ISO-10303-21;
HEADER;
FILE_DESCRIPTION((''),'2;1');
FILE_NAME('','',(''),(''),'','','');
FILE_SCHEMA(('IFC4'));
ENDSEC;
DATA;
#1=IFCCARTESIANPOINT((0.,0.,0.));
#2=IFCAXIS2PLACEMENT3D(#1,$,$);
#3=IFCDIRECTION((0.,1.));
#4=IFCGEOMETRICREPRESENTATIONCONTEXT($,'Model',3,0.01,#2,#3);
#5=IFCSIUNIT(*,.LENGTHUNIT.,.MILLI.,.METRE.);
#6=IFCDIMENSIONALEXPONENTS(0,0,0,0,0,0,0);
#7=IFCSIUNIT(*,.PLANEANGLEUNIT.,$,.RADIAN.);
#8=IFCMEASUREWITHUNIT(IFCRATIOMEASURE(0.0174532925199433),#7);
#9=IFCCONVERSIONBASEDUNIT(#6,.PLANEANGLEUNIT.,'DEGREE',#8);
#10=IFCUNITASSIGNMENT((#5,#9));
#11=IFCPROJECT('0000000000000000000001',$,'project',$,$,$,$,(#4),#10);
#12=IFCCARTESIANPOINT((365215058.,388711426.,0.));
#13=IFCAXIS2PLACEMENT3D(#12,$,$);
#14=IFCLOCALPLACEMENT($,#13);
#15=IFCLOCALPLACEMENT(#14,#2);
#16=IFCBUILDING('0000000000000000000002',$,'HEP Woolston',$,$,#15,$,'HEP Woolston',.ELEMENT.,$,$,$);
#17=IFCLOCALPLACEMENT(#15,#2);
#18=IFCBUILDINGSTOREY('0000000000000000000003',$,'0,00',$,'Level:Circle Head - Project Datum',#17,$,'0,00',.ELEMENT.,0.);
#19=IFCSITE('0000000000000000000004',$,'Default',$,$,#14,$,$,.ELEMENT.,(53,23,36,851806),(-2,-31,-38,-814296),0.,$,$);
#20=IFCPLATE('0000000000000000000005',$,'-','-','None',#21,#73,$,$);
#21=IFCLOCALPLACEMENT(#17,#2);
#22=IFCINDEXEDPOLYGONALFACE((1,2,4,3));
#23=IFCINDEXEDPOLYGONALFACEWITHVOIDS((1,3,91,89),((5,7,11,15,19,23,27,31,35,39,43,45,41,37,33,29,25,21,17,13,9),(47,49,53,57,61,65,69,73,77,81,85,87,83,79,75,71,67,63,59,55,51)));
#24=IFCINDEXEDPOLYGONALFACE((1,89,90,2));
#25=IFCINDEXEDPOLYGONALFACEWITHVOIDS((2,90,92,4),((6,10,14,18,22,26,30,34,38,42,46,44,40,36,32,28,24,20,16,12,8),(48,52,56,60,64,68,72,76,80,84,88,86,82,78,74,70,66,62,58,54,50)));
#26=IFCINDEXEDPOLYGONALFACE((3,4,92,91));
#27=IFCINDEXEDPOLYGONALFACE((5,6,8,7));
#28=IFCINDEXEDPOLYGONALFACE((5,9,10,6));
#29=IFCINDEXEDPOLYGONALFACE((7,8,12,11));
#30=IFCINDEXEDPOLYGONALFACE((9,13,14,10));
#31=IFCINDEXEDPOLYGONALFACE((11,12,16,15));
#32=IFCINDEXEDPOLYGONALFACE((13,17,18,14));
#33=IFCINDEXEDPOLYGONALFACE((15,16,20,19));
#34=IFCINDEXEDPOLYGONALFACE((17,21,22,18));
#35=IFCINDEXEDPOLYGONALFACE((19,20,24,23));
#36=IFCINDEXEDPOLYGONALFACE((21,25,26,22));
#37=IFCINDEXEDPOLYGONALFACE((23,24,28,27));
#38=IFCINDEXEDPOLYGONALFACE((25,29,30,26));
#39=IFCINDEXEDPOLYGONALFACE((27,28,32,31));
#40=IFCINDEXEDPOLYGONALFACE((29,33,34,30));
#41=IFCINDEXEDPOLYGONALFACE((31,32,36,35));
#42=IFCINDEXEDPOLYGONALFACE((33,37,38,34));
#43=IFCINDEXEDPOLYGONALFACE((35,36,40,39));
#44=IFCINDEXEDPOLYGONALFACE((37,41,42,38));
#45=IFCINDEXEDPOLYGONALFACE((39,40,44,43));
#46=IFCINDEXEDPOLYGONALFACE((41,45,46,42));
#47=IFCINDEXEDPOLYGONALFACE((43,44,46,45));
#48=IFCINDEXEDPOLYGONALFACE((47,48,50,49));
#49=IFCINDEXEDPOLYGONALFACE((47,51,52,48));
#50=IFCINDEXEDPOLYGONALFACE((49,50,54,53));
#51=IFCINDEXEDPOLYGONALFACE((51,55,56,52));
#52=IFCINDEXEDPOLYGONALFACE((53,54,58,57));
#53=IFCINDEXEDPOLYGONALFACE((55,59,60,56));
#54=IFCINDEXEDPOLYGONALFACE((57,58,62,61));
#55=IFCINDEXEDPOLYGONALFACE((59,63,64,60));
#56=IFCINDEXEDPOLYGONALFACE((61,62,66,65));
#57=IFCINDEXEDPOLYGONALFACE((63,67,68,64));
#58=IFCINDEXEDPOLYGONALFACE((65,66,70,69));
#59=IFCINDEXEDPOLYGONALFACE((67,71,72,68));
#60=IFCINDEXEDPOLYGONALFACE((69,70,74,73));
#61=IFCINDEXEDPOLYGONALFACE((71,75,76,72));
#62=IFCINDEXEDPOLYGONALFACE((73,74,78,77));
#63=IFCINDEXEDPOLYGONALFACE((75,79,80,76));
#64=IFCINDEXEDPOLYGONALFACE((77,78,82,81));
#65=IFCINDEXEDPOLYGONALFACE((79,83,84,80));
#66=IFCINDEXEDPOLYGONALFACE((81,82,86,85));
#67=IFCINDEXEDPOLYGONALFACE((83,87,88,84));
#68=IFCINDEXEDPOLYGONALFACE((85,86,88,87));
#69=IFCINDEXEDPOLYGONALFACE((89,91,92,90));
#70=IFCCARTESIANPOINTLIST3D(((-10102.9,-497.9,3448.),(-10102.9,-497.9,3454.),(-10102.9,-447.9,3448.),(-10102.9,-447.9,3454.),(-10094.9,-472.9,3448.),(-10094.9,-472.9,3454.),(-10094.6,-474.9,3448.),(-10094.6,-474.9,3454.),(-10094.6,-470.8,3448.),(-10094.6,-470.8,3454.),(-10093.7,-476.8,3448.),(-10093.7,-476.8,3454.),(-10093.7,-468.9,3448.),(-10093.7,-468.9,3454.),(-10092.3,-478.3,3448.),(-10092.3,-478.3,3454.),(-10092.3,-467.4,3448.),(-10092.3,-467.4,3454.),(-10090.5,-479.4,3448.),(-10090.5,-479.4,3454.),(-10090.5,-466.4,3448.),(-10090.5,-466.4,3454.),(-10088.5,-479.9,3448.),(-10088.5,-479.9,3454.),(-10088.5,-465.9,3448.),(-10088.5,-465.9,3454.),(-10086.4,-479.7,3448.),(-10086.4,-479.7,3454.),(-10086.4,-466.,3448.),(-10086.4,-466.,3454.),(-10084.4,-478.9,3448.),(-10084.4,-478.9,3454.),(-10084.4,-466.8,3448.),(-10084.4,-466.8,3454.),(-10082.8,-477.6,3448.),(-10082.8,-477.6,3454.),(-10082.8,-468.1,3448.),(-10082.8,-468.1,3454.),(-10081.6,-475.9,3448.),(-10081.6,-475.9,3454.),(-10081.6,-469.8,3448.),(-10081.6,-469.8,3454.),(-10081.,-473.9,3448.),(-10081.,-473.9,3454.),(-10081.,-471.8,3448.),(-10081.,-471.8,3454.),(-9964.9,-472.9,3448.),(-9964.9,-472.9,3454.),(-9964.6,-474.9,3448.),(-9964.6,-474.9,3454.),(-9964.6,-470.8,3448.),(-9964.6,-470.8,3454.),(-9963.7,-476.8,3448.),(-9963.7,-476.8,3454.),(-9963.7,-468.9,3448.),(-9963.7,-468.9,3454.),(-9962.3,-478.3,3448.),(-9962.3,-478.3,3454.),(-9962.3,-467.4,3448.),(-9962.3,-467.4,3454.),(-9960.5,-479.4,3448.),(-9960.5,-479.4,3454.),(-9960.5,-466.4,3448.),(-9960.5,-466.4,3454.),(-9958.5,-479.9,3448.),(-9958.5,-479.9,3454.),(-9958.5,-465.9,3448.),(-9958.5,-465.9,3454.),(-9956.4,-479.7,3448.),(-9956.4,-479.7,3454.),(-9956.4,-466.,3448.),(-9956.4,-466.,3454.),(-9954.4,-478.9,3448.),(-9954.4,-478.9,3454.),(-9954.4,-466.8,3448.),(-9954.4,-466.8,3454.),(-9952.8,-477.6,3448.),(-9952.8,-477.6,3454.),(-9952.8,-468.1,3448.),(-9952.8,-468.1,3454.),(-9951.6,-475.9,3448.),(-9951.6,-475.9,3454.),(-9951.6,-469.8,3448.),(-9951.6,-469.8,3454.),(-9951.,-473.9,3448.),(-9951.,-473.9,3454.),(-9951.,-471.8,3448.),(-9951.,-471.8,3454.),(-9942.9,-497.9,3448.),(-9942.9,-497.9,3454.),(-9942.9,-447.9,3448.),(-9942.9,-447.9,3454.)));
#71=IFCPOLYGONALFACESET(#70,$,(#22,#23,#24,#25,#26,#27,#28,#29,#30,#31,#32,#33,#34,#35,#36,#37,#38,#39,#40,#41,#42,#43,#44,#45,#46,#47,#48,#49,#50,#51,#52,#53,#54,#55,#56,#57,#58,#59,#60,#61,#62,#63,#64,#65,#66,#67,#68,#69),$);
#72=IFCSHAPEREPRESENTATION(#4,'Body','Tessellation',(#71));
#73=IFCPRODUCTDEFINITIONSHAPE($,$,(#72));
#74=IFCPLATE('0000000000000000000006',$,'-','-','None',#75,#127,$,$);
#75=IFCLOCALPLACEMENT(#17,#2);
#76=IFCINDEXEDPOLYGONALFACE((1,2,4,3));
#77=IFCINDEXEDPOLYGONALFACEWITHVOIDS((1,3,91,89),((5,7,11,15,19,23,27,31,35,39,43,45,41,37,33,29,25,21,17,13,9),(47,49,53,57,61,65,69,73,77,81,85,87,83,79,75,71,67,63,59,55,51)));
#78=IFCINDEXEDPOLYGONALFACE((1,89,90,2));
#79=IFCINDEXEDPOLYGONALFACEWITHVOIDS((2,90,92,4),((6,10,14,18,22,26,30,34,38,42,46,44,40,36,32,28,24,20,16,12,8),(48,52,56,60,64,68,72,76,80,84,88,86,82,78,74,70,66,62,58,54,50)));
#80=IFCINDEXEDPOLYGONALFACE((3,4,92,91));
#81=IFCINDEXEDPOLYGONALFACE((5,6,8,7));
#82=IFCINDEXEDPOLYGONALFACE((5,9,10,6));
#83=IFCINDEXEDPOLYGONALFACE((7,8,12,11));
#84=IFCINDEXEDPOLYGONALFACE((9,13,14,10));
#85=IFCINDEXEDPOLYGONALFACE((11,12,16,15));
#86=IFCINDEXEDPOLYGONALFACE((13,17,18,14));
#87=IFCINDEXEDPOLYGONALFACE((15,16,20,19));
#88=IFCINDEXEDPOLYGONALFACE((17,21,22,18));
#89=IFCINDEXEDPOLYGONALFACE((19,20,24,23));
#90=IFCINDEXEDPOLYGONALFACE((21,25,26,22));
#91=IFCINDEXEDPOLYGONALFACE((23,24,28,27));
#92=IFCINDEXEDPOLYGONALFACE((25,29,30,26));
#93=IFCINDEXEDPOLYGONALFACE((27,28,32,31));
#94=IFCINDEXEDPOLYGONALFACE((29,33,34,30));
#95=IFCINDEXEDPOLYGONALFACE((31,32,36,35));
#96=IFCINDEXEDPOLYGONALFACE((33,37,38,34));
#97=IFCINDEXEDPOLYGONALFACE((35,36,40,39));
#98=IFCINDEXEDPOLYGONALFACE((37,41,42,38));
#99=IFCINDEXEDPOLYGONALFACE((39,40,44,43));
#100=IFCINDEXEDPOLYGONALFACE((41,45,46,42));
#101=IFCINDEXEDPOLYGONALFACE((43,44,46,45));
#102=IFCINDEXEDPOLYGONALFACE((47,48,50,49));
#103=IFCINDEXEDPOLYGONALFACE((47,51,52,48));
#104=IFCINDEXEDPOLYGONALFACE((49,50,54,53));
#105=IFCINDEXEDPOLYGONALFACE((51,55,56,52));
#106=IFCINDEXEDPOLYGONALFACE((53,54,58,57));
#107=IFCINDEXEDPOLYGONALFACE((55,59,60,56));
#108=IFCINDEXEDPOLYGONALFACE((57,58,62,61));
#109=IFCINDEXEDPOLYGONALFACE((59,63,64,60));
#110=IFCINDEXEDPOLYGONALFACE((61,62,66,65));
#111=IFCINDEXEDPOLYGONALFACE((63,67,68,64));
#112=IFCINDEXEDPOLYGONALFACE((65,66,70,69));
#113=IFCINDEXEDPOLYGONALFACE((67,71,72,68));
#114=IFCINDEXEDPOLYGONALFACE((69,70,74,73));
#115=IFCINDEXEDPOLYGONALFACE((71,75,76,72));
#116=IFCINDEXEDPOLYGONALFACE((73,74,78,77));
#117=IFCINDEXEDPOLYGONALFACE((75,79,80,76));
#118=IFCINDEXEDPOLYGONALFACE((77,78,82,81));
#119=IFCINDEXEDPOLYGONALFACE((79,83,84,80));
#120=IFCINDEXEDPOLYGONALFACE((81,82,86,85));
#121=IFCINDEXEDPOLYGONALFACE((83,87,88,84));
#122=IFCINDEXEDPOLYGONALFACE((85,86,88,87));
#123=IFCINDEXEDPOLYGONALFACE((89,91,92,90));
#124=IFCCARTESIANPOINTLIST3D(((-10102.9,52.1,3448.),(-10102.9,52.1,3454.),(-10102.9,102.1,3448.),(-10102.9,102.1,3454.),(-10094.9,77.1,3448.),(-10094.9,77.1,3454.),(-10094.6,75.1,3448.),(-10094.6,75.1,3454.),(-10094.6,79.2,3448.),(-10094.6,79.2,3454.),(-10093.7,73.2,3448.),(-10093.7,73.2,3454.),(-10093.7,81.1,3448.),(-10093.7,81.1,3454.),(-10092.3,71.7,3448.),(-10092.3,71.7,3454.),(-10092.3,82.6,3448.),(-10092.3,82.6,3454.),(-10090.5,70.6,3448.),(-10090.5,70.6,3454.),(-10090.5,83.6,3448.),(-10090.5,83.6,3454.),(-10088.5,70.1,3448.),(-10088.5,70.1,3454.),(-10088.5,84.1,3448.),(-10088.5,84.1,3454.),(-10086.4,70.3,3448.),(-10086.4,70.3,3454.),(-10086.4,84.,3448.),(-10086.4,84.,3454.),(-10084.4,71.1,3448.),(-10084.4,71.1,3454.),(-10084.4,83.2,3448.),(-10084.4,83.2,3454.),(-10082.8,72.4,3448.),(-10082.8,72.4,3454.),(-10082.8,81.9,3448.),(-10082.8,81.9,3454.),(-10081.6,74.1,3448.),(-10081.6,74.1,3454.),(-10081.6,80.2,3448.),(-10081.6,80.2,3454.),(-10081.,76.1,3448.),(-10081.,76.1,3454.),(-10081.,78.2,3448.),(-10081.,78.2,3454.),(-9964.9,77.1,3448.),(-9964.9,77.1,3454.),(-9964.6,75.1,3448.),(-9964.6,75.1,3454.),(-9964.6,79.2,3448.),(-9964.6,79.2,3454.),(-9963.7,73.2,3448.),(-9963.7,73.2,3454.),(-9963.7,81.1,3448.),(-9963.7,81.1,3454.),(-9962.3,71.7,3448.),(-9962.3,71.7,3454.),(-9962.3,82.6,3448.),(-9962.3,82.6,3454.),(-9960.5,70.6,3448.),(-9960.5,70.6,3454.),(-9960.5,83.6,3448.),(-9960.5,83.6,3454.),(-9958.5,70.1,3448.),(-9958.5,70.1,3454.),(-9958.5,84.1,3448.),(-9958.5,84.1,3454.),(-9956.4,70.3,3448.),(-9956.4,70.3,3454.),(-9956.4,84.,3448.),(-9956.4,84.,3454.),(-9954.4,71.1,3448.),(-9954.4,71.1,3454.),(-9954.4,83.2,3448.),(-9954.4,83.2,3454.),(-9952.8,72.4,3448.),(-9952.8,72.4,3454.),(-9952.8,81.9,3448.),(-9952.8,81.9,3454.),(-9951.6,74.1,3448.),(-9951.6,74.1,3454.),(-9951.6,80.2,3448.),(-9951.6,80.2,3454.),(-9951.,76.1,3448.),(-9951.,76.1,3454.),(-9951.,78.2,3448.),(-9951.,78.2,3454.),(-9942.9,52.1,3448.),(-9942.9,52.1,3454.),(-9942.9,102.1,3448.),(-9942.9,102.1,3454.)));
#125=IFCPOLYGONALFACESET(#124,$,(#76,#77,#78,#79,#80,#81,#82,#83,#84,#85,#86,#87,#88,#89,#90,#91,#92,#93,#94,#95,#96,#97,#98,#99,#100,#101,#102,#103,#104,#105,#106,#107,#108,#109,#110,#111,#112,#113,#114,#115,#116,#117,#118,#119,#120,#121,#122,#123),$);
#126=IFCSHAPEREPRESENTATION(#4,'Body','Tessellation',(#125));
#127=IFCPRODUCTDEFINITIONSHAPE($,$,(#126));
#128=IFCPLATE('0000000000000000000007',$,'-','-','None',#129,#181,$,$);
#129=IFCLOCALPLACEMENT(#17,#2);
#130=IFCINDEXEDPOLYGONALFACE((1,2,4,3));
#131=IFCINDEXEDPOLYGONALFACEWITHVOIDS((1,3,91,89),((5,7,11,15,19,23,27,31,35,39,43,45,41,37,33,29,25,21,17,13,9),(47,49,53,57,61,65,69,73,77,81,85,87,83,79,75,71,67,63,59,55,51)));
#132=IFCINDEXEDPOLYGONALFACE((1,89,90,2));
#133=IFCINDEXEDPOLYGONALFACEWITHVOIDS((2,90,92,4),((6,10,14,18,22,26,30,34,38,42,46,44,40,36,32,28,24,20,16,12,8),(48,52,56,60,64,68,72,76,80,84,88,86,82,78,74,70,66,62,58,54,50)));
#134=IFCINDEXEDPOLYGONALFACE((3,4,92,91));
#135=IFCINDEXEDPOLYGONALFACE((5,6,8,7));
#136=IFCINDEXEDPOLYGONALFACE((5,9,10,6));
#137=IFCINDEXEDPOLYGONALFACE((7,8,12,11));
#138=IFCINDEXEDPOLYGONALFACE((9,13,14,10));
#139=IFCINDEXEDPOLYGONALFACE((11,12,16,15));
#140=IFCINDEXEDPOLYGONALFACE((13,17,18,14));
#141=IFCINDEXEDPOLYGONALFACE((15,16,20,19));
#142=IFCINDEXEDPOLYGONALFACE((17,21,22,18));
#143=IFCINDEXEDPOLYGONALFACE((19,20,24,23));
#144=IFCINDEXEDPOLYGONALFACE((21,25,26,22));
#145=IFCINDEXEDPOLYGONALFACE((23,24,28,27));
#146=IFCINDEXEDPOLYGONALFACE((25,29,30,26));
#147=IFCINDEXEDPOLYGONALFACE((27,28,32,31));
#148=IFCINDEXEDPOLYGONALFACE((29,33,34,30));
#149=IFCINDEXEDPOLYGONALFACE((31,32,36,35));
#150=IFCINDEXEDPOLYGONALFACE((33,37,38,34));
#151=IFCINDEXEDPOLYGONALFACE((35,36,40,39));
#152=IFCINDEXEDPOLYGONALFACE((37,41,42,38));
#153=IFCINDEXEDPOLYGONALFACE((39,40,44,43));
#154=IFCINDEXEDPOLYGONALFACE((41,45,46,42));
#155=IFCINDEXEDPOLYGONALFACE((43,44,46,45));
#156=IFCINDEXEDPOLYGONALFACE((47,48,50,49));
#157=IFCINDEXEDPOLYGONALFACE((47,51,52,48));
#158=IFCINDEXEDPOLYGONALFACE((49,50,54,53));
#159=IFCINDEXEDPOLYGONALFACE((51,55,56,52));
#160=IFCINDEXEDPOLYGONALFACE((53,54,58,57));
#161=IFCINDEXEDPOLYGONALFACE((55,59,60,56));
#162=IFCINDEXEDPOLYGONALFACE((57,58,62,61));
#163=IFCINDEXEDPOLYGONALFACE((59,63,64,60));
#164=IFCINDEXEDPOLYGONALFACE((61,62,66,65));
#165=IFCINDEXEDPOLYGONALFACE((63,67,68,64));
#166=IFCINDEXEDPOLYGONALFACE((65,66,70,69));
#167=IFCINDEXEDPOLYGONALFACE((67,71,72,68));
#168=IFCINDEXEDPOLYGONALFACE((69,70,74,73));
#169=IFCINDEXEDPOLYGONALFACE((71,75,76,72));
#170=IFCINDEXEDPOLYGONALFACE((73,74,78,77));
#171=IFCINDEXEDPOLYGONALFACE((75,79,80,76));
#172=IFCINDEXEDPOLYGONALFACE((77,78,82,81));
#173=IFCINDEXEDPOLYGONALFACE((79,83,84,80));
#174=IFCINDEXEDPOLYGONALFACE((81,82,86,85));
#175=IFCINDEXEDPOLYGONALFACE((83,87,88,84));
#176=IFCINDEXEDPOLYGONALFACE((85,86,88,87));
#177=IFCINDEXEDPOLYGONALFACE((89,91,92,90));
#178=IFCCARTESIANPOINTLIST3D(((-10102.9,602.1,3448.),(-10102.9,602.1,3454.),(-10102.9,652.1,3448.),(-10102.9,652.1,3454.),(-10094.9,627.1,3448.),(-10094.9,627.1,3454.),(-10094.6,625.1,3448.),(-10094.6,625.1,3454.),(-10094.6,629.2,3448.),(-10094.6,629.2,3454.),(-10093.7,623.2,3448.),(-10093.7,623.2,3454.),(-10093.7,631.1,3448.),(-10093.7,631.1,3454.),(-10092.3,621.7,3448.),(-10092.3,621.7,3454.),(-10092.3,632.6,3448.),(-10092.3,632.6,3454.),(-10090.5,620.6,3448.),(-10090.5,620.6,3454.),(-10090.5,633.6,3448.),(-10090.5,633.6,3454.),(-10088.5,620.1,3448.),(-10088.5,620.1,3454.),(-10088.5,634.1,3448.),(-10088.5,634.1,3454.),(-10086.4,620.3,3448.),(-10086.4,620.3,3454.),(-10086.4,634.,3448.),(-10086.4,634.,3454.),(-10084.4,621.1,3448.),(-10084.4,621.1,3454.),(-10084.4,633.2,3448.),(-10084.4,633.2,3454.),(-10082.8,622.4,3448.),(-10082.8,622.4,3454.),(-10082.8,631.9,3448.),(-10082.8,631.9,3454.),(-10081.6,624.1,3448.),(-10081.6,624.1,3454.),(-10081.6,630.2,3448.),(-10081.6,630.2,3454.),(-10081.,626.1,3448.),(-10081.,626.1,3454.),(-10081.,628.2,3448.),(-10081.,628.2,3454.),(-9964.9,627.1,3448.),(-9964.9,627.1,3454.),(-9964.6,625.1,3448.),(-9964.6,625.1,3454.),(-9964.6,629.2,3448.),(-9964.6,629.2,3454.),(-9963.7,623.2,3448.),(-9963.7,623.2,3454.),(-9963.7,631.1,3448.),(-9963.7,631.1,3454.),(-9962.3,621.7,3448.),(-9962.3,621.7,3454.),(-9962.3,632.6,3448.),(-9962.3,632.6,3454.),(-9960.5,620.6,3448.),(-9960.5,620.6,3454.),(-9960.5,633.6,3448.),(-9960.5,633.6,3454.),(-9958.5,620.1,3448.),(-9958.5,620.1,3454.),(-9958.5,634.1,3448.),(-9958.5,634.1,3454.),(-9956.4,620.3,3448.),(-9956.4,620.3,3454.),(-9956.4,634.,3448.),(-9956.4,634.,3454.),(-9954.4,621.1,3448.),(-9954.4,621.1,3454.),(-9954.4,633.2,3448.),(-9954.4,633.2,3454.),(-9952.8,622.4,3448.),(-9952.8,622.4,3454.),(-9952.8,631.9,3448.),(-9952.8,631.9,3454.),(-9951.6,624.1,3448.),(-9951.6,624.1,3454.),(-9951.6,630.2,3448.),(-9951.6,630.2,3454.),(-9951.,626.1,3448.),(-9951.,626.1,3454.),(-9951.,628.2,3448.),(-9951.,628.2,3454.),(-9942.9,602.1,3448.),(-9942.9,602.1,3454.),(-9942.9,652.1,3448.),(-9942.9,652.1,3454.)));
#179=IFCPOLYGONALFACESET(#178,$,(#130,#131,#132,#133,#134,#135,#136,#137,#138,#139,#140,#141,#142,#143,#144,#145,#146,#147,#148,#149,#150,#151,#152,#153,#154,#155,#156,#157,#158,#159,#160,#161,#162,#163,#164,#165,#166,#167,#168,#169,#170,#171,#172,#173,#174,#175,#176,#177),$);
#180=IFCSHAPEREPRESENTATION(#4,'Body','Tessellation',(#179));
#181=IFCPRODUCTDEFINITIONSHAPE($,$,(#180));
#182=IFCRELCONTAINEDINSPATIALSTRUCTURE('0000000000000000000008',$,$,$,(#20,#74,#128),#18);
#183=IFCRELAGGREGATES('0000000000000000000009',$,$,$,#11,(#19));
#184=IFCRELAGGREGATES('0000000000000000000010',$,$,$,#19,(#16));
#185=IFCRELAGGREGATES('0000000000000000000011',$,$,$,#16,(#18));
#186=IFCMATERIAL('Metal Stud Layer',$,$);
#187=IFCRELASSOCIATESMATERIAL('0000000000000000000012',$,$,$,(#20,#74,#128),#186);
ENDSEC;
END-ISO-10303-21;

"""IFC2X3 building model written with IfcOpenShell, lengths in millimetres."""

from ifc_helpers import new_model, entity, si_unit, converted_unit, direction, frame, frame_2d, origin, origin_with_axes, place, context, project, spatial, polyline, circle, outline, extrude, material, element, save


model = new_model("IFC2X3")

# Units and contexts
model_context = context("Model", 3, precision=0.01, world=origin(), true_north=direction((0.0, 1.0)))
ifc_project = project(units=[si_unit("LENGTHUNIT", "METRE", prefix="MILLI"), converted_unit("PLANEANGLEUNIT", "DEGREE", entity("IfcRatioMeasure", 0.0174532925199433), si_unit("PLANEANGLEUNIT", "RADIAN"), dimensions=[0, 0, 0, 0, 0, 0, 0])], contexts=[model_context])

# Site, building, storey
site_placement = place(None, frame((365215058.0, 388711426.0, 0.0)))
site = spatial("IfcSite", under=ifc_project, at=site_placement, Name="Default", CompositionType="ELEMENT", RefLatitude=(53, 23, 36, 851806), RefLongitude=(-2, -31, -38, -814296), RefElevation=0.0)
building_placement = place(site_placement, origin())
building = spatial("IfcBuilding", under=site, at=building_placement, Name="HEP Woolston", LongName="HEP Woolston", CompositionType="ELEMENT")
storey_placement = place(building_placement, origin())
storey = spatial("IfcBuildingStorey", under=building, at=storey_placement, Name="0,00", ObjectType="Level:Circle Head - Project Datum", LongName="0,00", CompositionType="ELEMENT", Elevation=0.0)

# Plates, openings
ifc_material = material(Name="Metal Stud Layer")
plate_1_placement = place(storey_placement, frame((-9942.9, -497.9, 3454.0), z_axis=(0.0, 0.0, -1.0), x_axis=(-1.0, 0.0, 0.0)))
plate_1 = element("IfcPlate", 1, at=plate_1_placement, inside=storey, material=ifc_material, Name="-", Description="-", ObjectType="None", context=model_context, shape_type="SweptSolid", body=[
    extrude(outline(polyline([(160.0, 0.0), (160.0, 50.0), (0.0, 50.0), (0.0, 0.0), (160.0, 0.0)])), origin_with_axes(), (0.0, 0.0, 1.0), 6.0),
])
opening_1_placement = place(plate_1_placement, frame((80.0, 25.0, 6.5), z_axis=(0.0, 0.0, -1.0), x_axis=(1.0, 0.0, 0.0)))
element("IfcOpeningElement", 2, at=opening_1_placement, cuts=plate_1, ObjectType="Opening", context=model_context, shape_type="SweptSolid", body=[
    extrude(circle(Radius=7.0, at=frame_2d((65.0, 0.0), x_axis=(1.0, 0.0))), origin(), (0.0, 0.0, 1.0), 7.0),
])
opening_2_placement = place(plate_1_placement, frame((80.0, 25.0, 6.5), z_axis=(0.0, 0.0, -1.0), x_axis=(1.0, 0.0, 0.0)))
element("IfcOpeningElement", 3, at=opening_2_placement, cuts=plate_1, ObjectType="Opening", context=model_context, shape_type="SweptSolid", body=[
    extrude(circle(Radius=7.0, at=frame_2d((-65.0, 0.0), x_axis=(1.0, 0.0))), origin(), (0.0, 0.0, 1.0), 7.0),
])
plate_2_placement = place(storey_placement, frame((-9942.9, 52.1, 3454.0), z_axis=(0.0, 0.0, -1.0), x_axis=(-1.0, 0.0, 0.0)))
plate_2 = element("IfcPlate", 4, at=plate_2_placement, inside=storey, material=ifc_material, Name="-", Description="-", ObjectType="None", context=model_context, shape_type="SweptSolid", body=[
    extrude(outline(polyline([(160.0, 0.0), (160.0, 50.0), (0.0, 50.0), (0.0, 0.0), (160.0, 0.0)])), origin_with_axes(), (0.0, 0.0, 1.0), 6.0),
])
opening_3_placement = place(plate_2_placement, frame((80.0, 25.0, 6.5), z_axis=(0.0, 0.0, -1.0), x_axis=(1.0, 0.0, 0.0)))
element("IfcOpeningElement", 5, at=opening_3_placement, cuts=plate_2, ObjectType="Opening", context=model_context, shape_type="SweptSolid", body=[
    extrude(circle(Radius=7.0, at=frame_2d((65.0, 0.0), x_axis=(1.0, 0.0))), origin(), (0.0, 0.0, 1.0), 7.0),
])
opening_4_placement = place(plate_2_placement, frame((80.0, 25.0, 6.5), z_axis=(0.0, 0.0, -1.0), x_axis=(1.0, 0.0, 0.0)))
element("IfcOpeningElement", 6, at=opening_4_placement, cuts=plate_2, ObjectType="Opening", context=model_context, shape_type="SweptSolid", body=[
    extrude(circle(Radius=7.0, at=frame_2d((-65.0, 0.0), x_axis=(1.0, 0.0))), origin(), (0.0, 0.0, 1.0), 7.0),
])
plate_3_placement = place(storey_placement, frame((-9942.9, 602.1, 3454.0), z_axis=(0.0, 0.0, -1.0), x_axis=(-1.0, 0.0, 0.0)))
plate_3 = element("IfcPlate", 7, at=plate_3_placement, inside=storey, material=ifc_material, Name="-", Description="-", ObjectType="None", context=model_context, shape_type="SweptSolid", body=[
    extrude(outline(polyline([(160.0, 0.0), (160.0, 50.0), (0.0, 50.0), (0.0, 0.0), (160.0, 0.0)])), origin_with_axes(), (0.0, 0.0, 1.0), 6.0),
])
opening_5_placement = place(plate_3_placement, frame((80.0, 25.0, 6.5), z_axis=(0.0, 0.0, -1.0), x_axis=(1.0, 0.0, 0.0)))
element("IfcOpeningElement", 8, at=opening_5_placement, cuts=plate_3, ObjectType="Opening", context=model_context, shape_type="SweptSolid", body=[
    extrude(circle(Radius=7.0, at=frame_2d((65.0, 0.0), x_axis=(1.0, 0.0))), origin(), (0.0, 0.0, 1.0), 7.0),
])
opening_6_placement = place(plate_3_placement, frame((80.0, 25.0, 6.5), z_axis=(0.0, 0.0, -1.0), x_axis=(1.0, 0.0, 0.0)))
element("IfcOpeningElement", 9, at=opening_6_placement, cuts=plate_3, ObjectType="Opening", context=model_context, shape_type="SweptSolid", body=[
    extrude(circle(Radius=7.0, at=frame_2d((-65.0, 0.0), x_axis=(1.0, 0.0))), origin(), (0.0, 0.0, 1.0), 7.0),
])

save(model, "model.ifc")
